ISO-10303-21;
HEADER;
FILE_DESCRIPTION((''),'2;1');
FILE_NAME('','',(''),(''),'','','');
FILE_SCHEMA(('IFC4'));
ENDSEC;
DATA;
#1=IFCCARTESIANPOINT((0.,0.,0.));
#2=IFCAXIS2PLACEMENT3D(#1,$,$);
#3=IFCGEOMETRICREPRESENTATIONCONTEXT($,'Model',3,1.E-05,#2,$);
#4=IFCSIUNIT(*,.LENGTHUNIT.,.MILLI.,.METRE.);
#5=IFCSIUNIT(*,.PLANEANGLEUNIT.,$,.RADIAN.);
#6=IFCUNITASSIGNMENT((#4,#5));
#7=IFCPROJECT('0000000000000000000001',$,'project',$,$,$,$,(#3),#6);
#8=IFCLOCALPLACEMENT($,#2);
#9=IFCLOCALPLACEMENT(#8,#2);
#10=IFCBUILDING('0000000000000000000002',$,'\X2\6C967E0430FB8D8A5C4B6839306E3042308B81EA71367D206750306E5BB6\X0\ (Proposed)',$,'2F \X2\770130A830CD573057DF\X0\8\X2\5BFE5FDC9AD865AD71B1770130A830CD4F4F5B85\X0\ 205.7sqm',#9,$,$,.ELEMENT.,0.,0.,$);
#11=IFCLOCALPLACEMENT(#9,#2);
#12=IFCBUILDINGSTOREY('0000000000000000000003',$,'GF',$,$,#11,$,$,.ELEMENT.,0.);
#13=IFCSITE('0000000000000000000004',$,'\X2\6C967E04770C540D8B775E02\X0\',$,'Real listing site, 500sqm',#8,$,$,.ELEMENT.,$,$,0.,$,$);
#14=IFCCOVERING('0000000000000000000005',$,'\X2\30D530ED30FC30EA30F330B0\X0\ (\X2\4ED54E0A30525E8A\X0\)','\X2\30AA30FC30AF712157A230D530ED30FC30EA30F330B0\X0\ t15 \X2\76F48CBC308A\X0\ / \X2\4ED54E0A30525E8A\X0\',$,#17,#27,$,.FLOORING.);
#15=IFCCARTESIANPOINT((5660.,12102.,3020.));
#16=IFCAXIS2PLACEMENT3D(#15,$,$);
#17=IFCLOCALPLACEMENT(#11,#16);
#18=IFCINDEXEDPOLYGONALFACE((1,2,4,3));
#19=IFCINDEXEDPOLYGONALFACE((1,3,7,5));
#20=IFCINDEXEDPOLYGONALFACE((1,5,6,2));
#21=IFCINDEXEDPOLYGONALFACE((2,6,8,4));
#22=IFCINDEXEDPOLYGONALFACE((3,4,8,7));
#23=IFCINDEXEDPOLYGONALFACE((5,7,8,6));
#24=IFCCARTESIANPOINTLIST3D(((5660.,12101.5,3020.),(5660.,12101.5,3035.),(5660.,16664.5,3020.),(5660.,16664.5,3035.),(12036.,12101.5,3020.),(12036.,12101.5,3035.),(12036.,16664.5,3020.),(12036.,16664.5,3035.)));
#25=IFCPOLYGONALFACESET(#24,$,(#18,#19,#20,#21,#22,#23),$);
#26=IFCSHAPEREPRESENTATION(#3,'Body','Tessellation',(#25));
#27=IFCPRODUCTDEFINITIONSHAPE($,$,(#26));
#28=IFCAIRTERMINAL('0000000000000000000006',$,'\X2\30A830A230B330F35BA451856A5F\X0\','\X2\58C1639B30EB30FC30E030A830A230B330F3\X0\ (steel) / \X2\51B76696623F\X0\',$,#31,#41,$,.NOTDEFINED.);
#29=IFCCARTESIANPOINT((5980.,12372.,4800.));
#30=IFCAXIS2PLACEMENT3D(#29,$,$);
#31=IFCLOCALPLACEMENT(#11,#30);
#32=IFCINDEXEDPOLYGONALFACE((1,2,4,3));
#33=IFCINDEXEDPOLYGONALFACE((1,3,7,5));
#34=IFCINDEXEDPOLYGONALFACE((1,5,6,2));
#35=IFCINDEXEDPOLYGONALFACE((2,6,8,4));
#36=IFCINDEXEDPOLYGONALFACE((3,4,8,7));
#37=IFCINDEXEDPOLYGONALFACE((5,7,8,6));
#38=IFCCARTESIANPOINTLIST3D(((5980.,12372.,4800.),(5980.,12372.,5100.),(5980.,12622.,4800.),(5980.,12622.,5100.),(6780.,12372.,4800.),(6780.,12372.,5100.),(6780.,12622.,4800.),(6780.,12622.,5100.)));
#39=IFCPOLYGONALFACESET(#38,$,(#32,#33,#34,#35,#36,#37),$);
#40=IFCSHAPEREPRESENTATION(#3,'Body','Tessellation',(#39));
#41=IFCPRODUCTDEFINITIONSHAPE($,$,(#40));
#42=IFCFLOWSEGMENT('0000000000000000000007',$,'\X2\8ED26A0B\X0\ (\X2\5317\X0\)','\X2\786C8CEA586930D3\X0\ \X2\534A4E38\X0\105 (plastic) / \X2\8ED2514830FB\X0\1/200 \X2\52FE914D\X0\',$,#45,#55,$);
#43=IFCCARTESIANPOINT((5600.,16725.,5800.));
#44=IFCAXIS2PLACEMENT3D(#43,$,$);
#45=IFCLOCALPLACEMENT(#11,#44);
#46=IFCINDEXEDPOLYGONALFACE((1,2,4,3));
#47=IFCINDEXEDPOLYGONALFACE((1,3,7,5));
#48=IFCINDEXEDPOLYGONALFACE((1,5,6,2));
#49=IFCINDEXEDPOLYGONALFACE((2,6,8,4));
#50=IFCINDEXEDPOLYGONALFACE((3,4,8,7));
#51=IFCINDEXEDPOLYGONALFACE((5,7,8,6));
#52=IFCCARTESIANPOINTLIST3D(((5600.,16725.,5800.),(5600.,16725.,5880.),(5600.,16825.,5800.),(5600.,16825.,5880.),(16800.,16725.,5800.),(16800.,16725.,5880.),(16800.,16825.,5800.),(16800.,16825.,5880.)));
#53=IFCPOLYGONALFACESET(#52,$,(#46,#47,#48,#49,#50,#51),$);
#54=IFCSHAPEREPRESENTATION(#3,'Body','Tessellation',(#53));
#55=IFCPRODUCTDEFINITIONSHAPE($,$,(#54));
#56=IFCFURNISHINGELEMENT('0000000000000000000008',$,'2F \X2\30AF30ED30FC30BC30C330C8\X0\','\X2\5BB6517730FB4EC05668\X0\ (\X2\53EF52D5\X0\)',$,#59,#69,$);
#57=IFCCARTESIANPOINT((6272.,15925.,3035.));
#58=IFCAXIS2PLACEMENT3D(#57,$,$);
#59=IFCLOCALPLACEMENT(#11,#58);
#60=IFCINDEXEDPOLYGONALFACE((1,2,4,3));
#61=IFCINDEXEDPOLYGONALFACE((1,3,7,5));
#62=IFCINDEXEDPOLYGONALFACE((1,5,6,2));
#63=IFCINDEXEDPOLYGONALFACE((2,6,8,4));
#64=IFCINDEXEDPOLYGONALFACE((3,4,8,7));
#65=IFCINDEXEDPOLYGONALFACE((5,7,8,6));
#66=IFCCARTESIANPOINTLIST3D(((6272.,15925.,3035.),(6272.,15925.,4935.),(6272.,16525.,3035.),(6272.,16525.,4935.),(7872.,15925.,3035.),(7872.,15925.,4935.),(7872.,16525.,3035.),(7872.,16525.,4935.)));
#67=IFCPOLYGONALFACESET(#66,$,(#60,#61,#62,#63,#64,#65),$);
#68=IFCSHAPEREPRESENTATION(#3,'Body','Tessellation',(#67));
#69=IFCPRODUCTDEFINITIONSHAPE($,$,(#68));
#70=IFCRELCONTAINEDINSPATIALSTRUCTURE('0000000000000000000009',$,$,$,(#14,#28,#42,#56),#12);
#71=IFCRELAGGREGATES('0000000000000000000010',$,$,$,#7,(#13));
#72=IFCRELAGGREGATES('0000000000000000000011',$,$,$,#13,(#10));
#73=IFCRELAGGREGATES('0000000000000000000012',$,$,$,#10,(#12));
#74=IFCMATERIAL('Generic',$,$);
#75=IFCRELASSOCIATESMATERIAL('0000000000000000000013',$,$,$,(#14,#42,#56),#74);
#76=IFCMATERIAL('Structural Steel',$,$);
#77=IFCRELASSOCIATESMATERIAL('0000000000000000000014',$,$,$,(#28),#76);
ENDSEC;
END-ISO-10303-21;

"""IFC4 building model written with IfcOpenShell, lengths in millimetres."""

from ifc_helpers import new_model, si_unit, frame, frame_2d, origin, place, context, project, spatial, rectangle, extrude, material, element, save


model = new_model("IFC4")

# Units and contexts
model_context = context("Model", 3, precision=1e-05, world=origin())
ifc_project = project(units=[si_unit("LENGTHUNIT", "METRE", prefix="MILLI"), si_unit("PLANEANGLEUNIT", "RADIAN")], contexts=[model_context])

# Site, building, storey
site_placement = place(None, origin())
site = spatial("IfcSite", under=ifc_project, at=site_placement, Name="沖縄県名護市", ObjectType="Real listing site, 500sqm", CompositionType="ELEMENT", RefElevation=0.0)
building_placement = place(site_placement, origin())
building = spatial("IfcBuilding", under=site, at=building_placement, Name="沖縄・越屋根のある自然素材の家 (Proposed)", ObjectType="2F 省エネ地域8対応高断熱省エネ住宅 205.7sqm", CompositionType="ELEMENT", ElevationOfRefHeight=0.0, ElevationOfTerrain=0.0)
storey_placement = place(building_placement, origin())
storey = spatial("IfcBuildingStorey", under=building, at=storey_placement, Name="GF", CompositionType="ELEMENT", Elevation=0.0)

# Shared definitions
ifc_material_1 = material(Name="Structural Steel")

# Covering
ifc_material_2 = material(Name="Generic")
covering_placement = place(storey_placement, frame((5660.0, 12102.0, 3020.0)))
element("IfcCovering", 1, at=covering_placement, inside=storey, material=ifc_material_2, Name="フローリング (仕上げ床)", Description="オーク無垢フローリング t15 直貼り / 仕上げ床", PredefinedType="FLOORING", context=model_context, shape_type="SweptSolid", body=[
    extrude(rectangle(XDim=6376.0, YDim=4563.0, at=frame_2d((3188.0, 2281.0))), frame((5660.0, 12102.0, 3020.0)), (0.0, 0.0, 1.0), 15.0),
])

# Air terminal
air_terminal_placement = place(storey_placement, frame((5980.0, 12372.0, 4800.0)))
element("IfcAirTerminal", 2, at=air_terminal_placement, inside=storey, material=ifc_material_1, Name="エアコン室内機", Description="壁掛ルームエアコン (steel) / 冷暖房", PredefinedType="NOTDEFINED", context=model_context, shape_type="SweptSolid", body=[
    extrude(rectangle(XDim=800.0, YDim=250.0, at=frame_2d((400.0, 125.0))), frame((5980.0, 12372.0, 4800.0)), (0.0, 0.0, 1.0), 300.0),
])

# Flow segment
flow_segment_placement = place(storey_placement, frame((5600.0, 16725.0, 5800.0)))
element("IfcFlowSegment", 3, at=flow_segment_placement, inside=storey, material=ifc_material_2, Name="軒樋 (北)", Description="硬質塩ビ 半丸105 (plastic) / 軒先・1/200 勾配", context=model_context, shape_type="SweptSolid", body=[
    extrude(rectangle(XDim=11200.0, YDim=100.0, at=frame_2d((5600.0, 50.0))), frame((5600.0, 16725.0, 5800.0)), (0.0, 0.0, 1.0), 80.0),
])

# Furnishing element
furnishing_placement = place(storey_placement, frame((6272.0, 15925.0, 3035.0)))
element("IfcFurnishingElement", 4, at=furnishing_placement, inside=storey, material=ifc_material_2, Name="2F クローゼット", Description="家具・什器 (可動)", context=model_context, shape_type="SweptSolid", body=[
    extrude(rectangle(XDim=1600.0, YDim=600.0, at=frame_2d((800.0, 300.0))), frame((6272.0, 15925.0, 3035.0)), (0.0, 0.0, 1.0), 1900.0),
])

save(model, "model.ifc")
